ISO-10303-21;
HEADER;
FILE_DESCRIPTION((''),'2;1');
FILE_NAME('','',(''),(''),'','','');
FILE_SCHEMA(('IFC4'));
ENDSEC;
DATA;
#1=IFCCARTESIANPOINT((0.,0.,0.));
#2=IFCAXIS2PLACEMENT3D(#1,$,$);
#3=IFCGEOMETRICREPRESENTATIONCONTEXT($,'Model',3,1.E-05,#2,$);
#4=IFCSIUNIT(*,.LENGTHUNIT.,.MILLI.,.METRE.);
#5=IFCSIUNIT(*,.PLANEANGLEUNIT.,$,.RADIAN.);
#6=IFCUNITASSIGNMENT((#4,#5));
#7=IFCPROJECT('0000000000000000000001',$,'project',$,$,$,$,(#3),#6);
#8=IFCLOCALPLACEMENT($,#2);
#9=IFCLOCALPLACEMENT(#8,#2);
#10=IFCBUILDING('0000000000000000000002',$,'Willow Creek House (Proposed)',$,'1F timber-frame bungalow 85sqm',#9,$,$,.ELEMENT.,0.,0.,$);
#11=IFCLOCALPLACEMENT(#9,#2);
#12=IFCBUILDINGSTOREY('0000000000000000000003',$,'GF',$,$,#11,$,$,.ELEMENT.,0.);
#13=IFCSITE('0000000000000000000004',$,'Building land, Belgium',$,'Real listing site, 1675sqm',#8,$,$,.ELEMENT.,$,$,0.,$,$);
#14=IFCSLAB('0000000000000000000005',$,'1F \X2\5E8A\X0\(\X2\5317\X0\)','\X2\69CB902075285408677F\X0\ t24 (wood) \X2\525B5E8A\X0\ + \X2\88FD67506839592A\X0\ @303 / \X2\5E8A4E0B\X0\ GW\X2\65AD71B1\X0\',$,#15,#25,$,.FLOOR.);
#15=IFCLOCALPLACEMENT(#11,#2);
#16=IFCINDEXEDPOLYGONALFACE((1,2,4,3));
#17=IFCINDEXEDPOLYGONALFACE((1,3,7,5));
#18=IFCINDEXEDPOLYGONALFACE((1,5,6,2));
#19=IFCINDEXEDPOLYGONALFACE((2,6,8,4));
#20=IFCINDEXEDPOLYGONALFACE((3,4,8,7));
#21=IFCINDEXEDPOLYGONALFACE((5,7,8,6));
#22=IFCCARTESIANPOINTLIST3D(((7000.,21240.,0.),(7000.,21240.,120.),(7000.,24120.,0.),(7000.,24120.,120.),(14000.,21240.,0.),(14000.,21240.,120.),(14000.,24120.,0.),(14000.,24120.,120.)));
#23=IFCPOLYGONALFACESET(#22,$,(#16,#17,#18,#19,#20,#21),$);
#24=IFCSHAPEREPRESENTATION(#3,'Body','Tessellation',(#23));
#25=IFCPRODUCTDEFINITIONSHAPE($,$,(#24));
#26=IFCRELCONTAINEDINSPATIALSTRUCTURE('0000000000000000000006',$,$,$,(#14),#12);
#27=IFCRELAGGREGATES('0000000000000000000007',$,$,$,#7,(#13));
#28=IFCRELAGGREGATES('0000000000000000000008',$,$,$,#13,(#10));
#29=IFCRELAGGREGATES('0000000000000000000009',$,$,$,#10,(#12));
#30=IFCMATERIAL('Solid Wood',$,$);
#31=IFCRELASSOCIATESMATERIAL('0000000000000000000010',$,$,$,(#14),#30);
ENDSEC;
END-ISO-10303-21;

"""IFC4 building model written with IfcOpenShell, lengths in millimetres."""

from ifc_helpers import new_model, si_unit, frame, frame_2d, origin, place, context, project, spatial, rectangle, extrude, material, element, save


model = new_model("IFC4")

# Units and contexts
model_context = context("Model", 3, precision=1e-05, world=origin())
ifc_project = project(units=[si_unit("LENGTHUNIT", "METRE", prefix="MILLI"), si_unit("PLANEANGLEUNIT", "RADIAN")], contexts=[model_context])

# Site, building, storey
site_placement = place(None, origin())
site = spatial("IfcSite", under=ifc_project, at=site_placement, Name="Building land, Belgium", ObjectType="Real listing site, 1675sqm", CompositionType="ELEMENT", RefElevation=0.0)
building_placement = place(site_placement, origin())
building = spatial("IfcBuilding", under=site, at=building_placement, Name="Willow Creek House (Proposed)", ObjectType="1F timber-frame bungalow 85sqm", CompositionType="ELEMENT", ElevationOfRefHeight=0.0, ElevationOfTerrain=0.0)
storey_placement = place(building_placement, origin())
storey = spatial("IfcBuildingStorey", under=building, at=storey_placement, Name="GF", CompositionType="ELEMENT", Elevation=0.0)

# Slab
ifc_material_1 = material(Name="Solid Wood")
slab_1_placement = place(storey_placement, frame((3500.0, 10620.0, 0.0)))
element("IfcSlab", 1, at=slab_1_placement, inside=storey, material=ifc_material_1, Name="1F 床(北)", Description="構造用合板 t24 (wood) 剛床 + 製材根太 @303 / 床下 GW断熱", PredefinedType="FLOOR", context=model_context, shape_type="SweptSolid", body=[
    extrude(rectangle(XDim=7000.0, YDim=2880.0, at=frame_2d((3500.0, 1440.0))), frame((3500.0, 10620.0, 0.0)), (0.0, 0.0, 1.0), 120.0),
])

save(model, "model.ifc")
